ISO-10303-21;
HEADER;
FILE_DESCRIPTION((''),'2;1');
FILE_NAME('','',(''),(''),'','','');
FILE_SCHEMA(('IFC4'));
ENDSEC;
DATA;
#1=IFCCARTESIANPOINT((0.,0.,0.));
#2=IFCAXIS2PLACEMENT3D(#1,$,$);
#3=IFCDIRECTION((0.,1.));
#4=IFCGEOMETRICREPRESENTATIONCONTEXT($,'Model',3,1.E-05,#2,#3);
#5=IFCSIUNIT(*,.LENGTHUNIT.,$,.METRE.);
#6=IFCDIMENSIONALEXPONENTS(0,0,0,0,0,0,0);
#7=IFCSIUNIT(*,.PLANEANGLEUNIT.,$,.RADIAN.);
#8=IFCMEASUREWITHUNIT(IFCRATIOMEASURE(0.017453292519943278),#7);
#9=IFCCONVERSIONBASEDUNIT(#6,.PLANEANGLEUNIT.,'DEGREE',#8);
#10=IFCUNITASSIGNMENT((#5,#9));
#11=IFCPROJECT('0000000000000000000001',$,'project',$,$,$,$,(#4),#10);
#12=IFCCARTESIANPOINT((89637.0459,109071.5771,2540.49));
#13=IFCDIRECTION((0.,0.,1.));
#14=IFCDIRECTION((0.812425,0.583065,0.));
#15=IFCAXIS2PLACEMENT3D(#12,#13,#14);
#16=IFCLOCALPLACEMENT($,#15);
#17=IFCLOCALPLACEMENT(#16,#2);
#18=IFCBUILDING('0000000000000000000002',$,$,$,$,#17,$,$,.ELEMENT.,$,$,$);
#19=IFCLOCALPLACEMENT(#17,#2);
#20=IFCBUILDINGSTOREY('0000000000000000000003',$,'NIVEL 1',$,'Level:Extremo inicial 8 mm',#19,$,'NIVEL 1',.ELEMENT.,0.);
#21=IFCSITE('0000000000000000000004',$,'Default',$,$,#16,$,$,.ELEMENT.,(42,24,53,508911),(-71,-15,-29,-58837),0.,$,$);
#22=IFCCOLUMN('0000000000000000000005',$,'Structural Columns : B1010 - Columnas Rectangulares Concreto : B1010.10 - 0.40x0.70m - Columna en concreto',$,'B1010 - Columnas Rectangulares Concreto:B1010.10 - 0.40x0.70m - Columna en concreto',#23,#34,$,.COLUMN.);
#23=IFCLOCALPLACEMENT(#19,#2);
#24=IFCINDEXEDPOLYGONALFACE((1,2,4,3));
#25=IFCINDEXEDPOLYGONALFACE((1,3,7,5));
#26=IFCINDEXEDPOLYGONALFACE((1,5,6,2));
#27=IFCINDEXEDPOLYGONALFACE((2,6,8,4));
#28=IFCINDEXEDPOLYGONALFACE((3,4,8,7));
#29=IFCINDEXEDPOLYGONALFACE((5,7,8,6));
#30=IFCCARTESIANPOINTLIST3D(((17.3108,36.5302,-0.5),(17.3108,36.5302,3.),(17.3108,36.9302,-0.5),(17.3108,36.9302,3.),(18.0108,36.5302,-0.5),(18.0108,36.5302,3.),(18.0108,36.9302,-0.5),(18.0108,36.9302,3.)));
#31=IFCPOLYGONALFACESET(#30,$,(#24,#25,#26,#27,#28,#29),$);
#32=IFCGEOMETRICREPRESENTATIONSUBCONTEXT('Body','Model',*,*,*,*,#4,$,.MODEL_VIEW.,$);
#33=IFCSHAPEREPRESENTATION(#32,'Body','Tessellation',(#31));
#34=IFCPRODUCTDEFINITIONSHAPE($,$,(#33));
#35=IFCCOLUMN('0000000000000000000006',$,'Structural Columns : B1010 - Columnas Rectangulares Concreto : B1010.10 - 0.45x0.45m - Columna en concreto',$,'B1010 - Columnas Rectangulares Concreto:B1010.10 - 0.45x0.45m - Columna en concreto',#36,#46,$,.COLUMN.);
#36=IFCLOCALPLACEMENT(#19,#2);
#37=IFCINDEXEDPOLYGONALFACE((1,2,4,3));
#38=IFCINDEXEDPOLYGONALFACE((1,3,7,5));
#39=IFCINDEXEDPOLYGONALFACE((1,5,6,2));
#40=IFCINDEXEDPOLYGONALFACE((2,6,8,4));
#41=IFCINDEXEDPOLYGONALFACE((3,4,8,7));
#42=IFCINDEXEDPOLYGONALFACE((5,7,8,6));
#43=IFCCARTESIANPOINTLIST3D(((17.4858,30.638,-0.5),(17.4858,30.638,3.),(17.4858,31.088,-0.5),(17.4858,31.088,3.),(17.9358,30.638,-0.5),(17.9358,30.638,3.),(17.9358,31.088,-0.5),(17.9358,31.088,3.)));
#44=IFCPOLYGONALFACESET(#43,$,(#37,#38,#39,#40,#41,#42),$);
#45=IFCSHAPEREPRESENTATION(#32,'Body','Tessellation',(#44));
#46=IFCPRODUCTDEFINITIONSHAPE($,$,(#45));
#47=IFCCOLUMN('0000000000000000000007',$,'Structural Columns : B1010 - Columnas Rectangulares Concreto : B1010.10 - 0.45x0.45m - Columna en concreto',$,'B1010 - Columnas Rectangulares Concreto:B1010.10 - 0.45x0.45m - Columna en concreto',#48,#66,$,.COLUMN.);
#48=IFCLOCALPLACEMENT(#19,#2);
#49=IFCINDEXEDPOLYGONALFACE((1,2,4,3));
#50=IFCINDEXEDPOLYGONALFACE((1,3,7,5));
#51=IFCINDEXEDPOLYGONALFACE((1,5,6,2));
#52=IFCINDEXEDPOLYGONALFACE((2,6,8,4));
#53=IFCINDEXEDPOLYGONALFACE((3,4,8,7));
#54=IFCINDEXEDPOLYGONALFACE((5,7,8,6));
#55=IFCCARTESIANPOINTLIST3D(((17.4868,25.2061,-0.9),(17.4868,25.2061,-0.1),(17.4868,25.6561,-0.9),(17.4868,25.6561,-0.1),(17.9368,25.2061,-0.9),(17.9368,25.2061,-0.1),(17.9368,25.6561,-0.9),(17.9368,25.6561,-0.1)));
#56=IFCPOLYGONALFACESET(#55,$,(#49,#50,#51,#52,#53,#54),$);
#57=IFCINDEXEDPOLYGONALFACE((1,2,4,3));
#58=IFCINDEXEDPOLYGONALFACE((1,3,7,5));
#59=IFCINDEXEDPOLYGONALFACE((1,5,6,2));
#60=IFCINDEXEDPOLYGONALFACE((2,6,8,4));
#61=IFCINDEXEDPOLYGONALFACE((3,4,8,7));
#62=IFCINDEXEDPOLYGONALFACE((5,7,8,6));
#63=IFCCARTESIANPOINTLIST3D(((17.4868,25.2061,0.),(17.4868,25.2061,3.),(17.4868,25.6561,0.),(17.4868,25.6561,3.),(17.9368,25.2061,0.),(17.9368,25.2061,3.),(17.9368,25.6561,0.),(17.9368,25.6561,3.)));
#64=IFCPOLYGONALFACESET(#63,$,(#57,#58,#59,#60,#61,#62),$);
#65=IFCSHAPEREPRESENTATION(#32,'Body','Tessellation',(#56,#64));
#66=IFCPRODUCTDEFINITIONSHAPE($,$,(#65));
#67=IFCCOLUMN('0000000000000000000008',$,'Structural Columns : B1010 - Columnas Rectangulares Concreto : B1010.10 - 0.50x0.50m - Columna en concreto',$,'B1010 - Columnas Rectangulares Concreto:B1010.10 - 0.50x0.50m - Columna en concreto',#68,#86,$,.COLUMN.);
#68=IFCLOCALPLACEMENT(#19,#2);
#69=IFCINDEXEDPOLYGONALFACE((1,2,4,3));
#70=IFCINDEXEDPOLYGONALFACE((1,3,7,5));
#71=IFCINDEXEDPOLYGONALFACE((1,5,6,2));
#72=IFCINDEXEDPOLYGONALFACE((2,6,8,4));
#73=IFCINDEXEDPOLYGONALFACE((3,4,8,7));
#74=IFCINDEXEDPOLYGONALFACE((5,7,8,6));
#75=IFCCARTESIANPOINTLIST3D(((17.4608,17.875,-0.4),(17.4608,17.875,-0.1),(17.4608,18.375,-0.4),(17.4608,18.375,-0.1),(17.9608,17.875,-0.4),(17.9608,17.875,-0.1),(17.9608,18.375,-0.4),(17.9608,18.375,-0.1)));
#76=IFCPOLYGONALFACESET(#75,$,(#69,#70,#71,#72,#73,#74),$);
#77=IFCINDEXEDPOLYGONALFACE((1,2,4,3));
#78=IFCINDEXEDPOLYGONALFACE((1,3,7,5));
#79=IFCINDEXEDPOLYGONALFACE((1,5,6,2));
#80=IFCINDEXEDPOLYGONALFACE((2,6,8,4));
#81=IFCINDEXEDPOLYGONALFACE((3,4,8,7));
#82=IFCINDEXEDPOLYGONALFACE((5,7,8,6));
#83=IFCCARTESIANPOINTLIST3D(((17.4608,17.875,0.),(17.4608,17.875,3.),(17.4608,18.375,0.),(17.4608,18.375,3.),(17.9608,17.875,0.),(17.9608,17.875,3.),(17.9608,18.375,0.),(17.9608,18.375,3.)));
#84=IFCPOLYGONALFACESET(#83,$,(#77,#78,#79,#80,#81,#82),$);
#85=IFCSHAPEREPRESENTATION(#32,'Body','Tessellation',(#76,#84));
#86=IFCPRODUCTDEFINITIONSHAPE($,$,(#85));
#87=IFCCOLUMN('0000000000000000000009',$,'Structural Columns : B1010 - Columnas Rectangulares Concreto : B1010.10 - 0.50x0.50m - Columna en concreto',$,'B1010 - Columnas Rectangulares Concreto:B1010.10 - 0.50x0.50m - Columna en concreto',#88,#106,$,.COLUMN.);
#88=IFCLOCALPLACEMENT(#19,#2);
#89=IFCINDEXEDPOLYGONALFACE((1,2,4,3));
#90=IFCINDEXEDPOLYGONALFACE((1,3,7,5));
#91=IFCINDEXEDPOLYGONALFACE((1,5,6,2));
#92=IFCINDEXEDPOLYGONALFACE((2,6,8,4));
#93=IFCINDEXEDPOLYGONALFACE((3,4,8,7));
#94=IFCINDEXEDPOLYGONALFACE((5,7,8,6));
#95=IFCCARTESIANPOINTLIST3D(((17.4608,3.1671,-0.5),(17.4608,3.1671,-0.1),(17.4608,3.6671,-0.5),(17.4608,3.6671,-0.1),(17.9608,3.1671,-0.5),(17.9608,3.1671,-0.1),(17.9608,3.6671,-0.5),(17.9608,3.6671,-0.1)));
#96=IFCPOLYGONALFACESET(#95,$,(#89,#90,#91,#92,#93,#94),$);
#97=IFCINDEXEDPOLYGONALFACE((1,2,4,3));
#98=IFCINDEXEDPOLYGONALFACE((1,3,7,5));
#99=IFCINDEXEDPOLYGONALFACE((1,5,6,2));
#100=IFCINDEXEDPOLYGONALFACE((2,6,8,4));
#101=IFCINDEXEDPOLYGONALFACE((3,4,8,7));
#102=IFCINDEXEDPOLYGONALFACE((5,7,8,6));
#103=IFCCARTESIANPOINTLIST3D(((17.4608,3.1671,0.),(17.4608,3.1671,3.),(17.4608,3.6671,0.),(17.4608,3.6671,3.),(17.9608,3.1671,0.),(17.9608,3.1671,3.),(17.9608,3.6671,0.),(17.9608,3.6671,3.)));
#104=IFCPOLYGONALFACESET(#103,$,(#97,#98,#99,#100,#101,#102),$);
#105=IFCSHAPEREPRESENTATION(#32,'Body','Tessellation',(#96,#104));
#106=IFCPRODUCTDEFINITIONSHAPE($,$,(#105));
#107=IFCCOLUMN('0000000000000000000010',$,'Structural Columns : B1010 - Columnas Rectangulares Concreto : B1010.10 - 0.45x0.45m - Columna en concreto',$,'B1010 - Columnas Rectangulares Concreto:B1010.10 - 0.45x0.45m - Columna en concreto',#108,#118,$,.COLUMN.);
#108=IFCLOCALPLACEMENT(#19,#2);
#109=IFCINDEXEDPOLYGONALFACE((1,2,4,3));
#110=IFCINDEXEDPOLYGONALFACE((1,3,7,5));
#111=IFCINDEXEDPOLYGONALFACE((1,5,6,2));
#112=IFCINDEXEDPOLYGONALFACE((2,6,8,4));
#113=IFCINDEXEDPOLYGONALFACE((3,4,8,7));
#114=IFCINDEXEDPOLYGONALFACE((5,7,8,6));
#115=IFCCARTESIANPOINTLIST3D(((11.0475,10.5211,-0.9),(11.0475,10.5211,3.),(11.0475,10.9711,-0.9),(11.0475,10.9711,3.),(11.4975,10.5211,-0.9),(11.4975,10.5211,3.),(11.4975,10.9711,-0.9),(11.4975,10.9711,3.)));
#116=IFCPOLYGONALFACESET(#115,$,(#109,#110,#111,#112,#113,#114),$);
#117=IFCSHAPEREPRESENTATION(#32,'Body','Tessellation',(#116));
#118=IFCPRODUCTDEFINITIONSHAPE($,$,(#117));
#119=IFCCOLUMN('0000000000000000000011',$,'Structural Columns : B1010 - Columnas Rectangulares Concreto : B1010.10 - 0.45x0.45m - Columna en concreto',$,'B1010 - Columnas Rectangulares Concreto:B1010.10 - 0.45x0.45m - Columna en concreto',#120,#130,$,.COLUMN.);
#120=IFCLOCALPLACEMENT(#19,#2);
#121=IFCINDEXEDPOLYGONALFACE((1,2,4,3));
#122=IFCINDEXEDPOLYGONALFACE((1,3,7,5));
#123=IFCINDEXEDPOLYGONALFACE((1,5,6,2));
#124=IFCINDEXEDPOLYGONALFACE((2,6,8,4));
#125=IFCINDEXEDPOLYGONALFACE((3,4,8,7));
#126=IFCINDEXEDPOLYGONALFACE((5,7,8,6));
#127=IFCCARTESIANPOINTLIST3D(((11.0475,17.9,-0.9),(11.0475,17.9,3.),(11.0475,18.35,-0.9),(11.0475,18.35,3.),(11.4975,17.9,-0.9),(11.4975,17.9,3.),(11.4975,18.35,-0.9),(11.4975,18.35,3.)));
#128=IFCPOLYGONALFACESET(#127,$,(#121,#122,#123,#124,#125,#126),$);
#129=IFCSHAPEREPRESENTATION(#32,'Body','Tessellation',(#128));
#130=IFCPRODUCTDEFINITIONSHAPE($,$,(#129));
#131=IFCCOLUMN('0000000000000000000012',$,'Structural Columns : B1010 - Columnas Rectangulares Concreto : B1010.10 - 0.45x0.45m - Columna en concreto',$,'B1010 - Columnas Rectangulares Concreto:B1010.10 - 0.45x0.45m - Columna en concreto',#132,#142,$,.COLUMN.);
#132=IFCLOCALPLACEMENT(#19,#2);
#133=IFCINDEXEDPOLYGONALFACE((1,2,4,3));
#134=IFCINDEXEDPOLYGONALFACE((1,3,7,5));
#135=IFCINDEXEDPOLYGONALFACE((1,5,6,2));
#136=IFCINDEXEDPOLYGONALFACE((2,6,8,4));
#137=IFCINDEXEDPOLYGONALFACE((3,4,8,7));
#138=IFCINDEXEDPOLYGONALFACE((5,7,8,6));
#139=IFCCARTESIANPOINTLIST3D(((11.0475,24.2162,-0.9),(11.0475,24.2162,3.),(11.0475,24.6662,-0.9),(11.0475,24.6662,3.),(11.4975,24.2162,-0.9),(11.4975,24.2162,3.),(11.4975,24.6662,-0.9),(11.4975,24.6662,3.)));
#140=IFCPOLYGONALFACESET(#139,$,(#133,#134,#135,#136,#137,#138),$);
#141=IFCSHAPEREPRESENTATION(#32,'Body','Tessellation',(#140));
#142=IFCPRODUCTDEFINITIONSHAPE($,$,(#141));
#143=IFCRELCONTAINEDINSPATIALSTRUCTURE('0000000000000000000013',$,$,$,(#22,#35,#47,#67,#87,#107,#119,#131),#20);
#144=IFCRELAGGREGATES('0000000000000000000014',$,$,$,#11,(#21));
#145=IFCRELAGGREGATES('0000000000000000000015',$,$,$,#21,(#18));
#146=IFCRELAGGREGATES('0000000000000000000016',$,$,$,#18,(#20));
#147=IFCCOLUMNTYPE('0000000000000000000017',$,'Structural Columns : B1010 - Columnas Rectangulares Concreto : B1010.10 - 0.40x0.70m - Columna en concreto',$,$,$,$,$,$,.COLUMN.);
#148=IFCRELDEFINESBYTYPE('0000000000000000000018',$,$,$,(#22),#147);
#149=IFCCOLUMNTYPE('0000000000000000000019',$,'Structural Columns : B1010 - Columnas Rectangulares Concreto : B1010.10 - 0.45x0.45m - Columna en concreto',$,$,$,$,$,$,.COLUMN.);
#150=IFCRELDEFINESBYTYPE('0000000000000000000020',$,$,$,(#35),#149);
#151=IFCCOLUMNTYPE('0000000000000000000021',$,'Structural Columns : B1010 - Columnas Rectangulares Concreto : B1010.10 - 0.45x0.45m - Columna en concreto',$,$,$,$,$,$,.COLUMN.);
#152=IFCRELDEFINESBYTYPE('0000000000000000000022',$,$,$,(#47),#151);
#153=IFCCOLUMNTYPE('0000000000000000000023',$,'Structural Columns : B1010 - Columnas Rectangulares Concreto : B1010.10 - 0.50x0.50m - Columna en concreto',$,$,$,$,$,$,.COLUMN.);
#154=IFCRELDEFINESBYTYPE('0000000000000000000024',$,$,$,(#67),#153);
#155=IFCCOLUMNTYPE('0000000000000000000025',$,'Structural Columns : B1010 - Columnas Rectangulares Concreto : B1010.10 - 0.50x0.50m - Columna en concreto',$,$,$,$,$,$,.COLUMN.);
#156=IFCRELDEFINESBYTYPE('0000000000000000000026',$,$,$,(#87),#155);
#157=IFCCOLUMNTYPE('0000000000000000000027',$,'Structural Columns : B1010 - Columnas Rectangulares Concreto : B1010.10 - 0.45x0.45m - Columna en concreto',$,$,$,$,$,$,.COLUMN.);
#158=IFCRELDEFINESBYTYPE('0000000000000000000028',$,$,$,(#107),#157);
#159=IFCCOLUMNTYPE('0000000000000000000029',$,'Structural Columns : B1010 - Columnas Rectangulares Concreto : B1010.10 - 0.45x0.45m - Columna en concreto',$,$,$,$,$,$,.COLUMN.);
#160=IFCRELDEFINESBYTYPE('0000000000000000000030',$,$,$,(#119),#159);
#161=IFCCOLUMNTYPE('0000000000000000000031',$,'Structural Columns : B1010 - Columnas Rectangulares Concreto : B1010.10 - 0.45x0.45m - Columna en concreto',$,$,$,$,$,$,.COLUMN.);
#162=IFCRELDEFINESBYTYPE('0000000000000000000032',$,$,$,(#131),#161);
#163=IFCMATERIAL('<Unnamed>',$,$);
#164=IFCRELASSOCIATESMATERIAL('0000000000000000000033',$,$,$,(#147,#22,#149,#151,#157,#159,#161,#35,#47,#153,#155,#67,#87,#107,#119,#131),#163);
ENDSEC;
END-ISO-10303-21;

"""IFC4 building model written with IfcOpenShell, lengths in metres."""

from ifc_helpers import new_model, entity, si_unit, converted_unit, direction, frame, origin, origin_2d_with_axis, place, context, subcontext, project, spatial, polyline, segment, composite_curve, rectangle, outline, extrude, source, transform, mapped, material, material_profile, profile_set, profile_usage, type_object, type_shapes, element, save


model = new_model("IFC4")

# Units and contexts
model_context = context("Model", 3, precision=1e-05, world=origin(), true_north=direction((0.0, 1.0)))
body_context = subcontext(model_context, "Body", "Model", "MODEL_VIEW")
ifc_project = project(units=[si_unit("LENGTHUNIT", "METRE"), converted_unit("PLANEANGLEUNIT", "DEGREE", entity("IfcRatioMeasure", 0.017453292519943278), si_unit("PLANEANGLEUNIT", "RADIAN"), dimensions=[0, 0, 0, 0, 0, 0, 0])], contexts=[model_context])

# Site, building, storey
site_placement = place(None, frame((89637.0459, 109071.5771, 2540.49), z_axis=(0.0, 0.0, 1.0), x_axis=(0.812425, 0.583065, 0.0)))
site = spatial("IfcSite", under=ifc_project, at=site_placement, Name="Default", CompositionType="ELEMENT", RefLatitude=(42, 24, 53, 508911), RefLongitude=(-71, -15, -29, -58837), RefElevation=0.0)
building_placement = place(site_placement, origin())
building = spatial("IfcBuilding", under=site, at=building_placement, CompositionType="ELEMENT")
storey_placement = place(building_placement, origin())
storey = spatial("IfcBuildingStorey", under=building, at=storey_placement, Name="NIVEL 1", ObjectType="Level:Extremo inicial 8 mm", LongName="NIVEL 1", CompositionType="ELEMENT", Elevation=0.0)

# Columns
ifc_material = material(Name="<Unnamed>")
ifc_material_profile_1 = material_profile(ifc_material, outline(composite_curve([segment(polyline([(0.35, 0.2, 0.0), (0.35, -0.2, 0.0)]), True, "CONTINUOUS"), segment(polyline([(0.35, -0.2, 0.0), (-0.35, -0.2, 0.0)]), True, "CONTINUOUS"), segment(polyline([(-0.35, -0.2, 0.0), (-0.35, 0.2, 0.0)]), True, "CONTINUOUS"), segment(polyline([(-0.35, 0.2, 0.0), (0.35, 0.2, 0.0)]), True, "CONTINUOUS")], self_intersect=False), kind="CURVE"), Name="B1010.10 - 0.40x0.70m - Columna en concreto")
ifc_material_profile_2 = material_profile(ifc_material, outline(composite_curve([segment(polyline([(0.35, 0.2, 3.0), (-0.35, 0.2, 3.0)]), True, "CONTINUOUS"), segment(polyline([(-0.35, 0.2, 3.0), (-0.35, -0.2, 3.0)]), True, "CONTINUOUS"), segment(polyline([(-0.35, -0.2, 3.0), (0.35, -0.2, 3.0)]), True, "CONTINUOUS"), segment(polyline([(0.35, -0.2, 3.0), (0.35, 0.2, 3.0)]), True, "CONTINUOUS")], self_intersect=False), kind="CURVE"), Name="B1010.10 - 0.40x0.70m - Columna en concreto")
ifc_profile_set_1 = profile_set([ifc_material_profile_1, ifc_material_profile_2], Name="B1010.10 - 0.40x0.70m - Columna en concreto")
ifc_profile_usage_1 = profile_usage(ifc_profile_set_1)
column_type_1 = type_object("IfcColumnType", Name="Structural Columns : B1010 - Columnas Rectangulares Concreto : B1010.10 - 0.40x0.70m - Columna en concreto", PredefinedType="COLUMN", material=ifc_profile_set_1)
shared_shape_1 = source(origin(), body_context, "Body", "SweptSolid", [
    extrude(rectangle(XDim=0.4, YDim=0.7, at=origin_2d_with_axis()), frame((17.6608, 36.7302, -0.5), z_axis=(0.0, 0.0, 1.0), x_axis=(0.0, -1.0, 0.0)), (0.0, 0.0, 1.0), 3.5),
])
type_shapes(column_type_1, [shared_shape_1])
column_1_placement = place(storey_placement, origin())
element("IfcColumn", 1, at=column_1_placement, inside=storey, type_object=column_type_1, material=ifc_profile_usage_1, Name="Structural Columns : B1010 - Columnas Rectangulares Concreto : B1010.10 - 0.40x0.70m - Columna en concreto", ObjectType="B1010 - Columnas Rectangulares Concreto:B1010.10 - 0.40x0.70m - Columna en concreto", PredefinedType="COLUMN", context=body_context, shape_type="MappedRepresentation", body=[
    mapped(shared_shape_1, transform((0.0, 0.0, 0.0), scale=1.0)),
])
ifc_material_profile_3 = material_profile(ifc_material, outline(composite_curve([segment(polyline([(0.225, 0.225, 0.0), (0.225, -0.225, 0.0)]), True, "CONTINUOUS"), segment(polyline([(0.225, -0.225, 0.0), (-0.225, -0.225, 0.0)]), True, "CONTINUOUS"), segment(polyline([(-0.225, -0.225, 0.0), (-0.225, 0.225, 0.0)]), True, "CONTINUOUS"), segment(polyline([(-0.225, 0.225, 0.0), (0.225, 0.225, 0.0)]), True, "CONTINUOUS")], self_intersect=False), kind="CURVE"), Name="B1010.10 - 0.45x0.45m - Columna en concreto")
ifc_material_profile_4 = material_profile(ifc_material, outline(composite_curve([segment(polyline([(0.225, 0.225, 3.0), (-0.225, 0.225, 3.0)]), True, "CONTINUOUS"), segment(polyline([(-0.225, 0.225, 3.0), (-0.225, -0.225, 3.0)]), True, "CONTINUOUS"), segment(polyline([(-0.225, -0.225, 3.0), (0.225, -0.225, 3.0)]), True, "CONTINUOUS"), segment(polyline([(0.225, -0.225, 3.0), (0.225, 0.225, 3.0)]), True, "CONTINUOUS")], self_intersect=False), kind="CURVE"), Name="B1010.10 - 0.45x0.45m - Columna en concreto")
ifc_profile_set_2 = profile_set([ifc_material_profile_3, ifc_material_profile_4], Name="B1010.10 - 0.45x0.45m - Columna en concreto")
ifc_profile_usage_2 = profile_usage(ifc_profile_set_2)
column_type_2 = type_object("IfcColumnType", Name="Structural Columns : B1010 - Columnas Rectangulares Concreto : B1010.10 - 0.45x0.45m - Columna en concreto", PredefinedType="COLUMN", material=ifc_profile_set_2)
shared_shape_2 = source(origin(), body_context, "Body", "SweptSolid", [
    extrude(rectangle(XDim=0.45, YDim=0.45, at=origin_2d_with_axis()), frame((17.7108, 30.863, -0.5), z_axis=(0.0, 0.0, 1.0), x_axis=(0.0, -1.0, 0.0)), (0.0, 0.0, 1.0), 3.5),
])
type_shapes(column_type_2, [shared_shape_2])
column_2_placement = place(storey_placement, origin())
element("IfcColumn", 2, at=column_2_placement, inside=storey, type_object=column_type_2, material=ifc_profile_usage_2, Name="Structural Columns : B1010 - Columnas Rectangulares Concreto : B1010.10 - 0.45x0.45m - Columna en concreto", ObjectType="B1010 - Columnas Rectangulares Concreto:B1010.10 - 0.45x0.45m - Columna en concreto", PredefinedType="COLUMN", context=body_context, shape_type="MappedRepresentation", body=[
    mapped(shared_shape_2, transform((0.0, 0.0, 0.0), scale=1.0)),
])
ifc_profile_usage_3 = profile_usage(ifc_profile_set_2)
column_type_3 = type_object("IfcColumnType", Name="Structural Columns : B1010 - Columnas Rectangulares Concreto : B1010.10 - 0.45x0.45m - Columna en concreto", PredefinedType="COLUMN", material=ifc_profile_set_2)
shared_shape_3 = source(origin(), body_context, "Body", "SweptSolid", [
    extrude(rectangle(XDim=0.45, YDim=0.45, at=origin_2d_with_axis()), frame((17.7118, 25.4311, -0.9), z_axis=(0.0, 0.0, 1.0), x_axis=(0.0, -1.0, 0.0)), (0.0, 0.0, 1.0), 0.8),
    extrude(rectangle(XDim=0.45, YDim=0.45, at=origin_2d_with_axis()), frame((17.7118, 25.4311, 0.0), z_axis=(0.0, 0.0, 1.0), x_axis=(0.0, -1.0, 0.0)), (0.0, 0.0, 1.0), 3.0),
])
type_shapes(column_type_3, [shared_shape_3])
column_3_placement = place(storey_placement, origin())
element("IfcColumn", 3, at=column_3_placement, inside=storey, type_object=column_type_3, material=ifc_profile_usage_3, Name="Structural Columns : B1010 - Columnas Rectangulares Concreto : B1010.10 - 0.45x0.45m - Columna en concreto", ObjectType="B1010 - Columnas Rectangulares Concreto:B1010.10 - 0.45x0.45m - Columna en concreto", PredefinedType="COLUMN", context=body_context, shape_type="MappedRepresentation", body=[
    mapped(shared_shape_3, transform((0.0, 0.0, 0.0), scale=1.0)),
])
ifc_material_profile_5 = material_profile(ifc_material, outline(composite_curve([segment(polyline([(0.25, 0.25, 0.0), (0.25, -0.25, 0.0)]), True, "CONTINUOUS"), segment(polyline([(0.25, -0.25, 0.0), (-0.25, -0.25, 0.0)]), True, "CONTINUOUS"), segment(polyline([(-0.25, -0.25, 0.0), (-0.25, 0.25, 0.0)]), True, "CONTINUOUS"), segment(polyline([(-0.25, 0.25, 0.0), (0.25, 0.25, 0.0)]), True, "CONTINUOUS")], self_intersect=False), kind="CURVE"), Name="B1010.10 - 0.50x0.50m - Columna en concreto")
ifc_material_profile_6 = material_profile(ifc_material, outline(composite_curve([segment(polyline([(0.25, 0.25, 3.0), (-0.25, 0.25, 3.0)]), True, "CONTINUOUS"), segment(polyline([(-0.25, 0.25, 3.0), (-0.25, -0.25, 3.0)]), True, "CONTINUOUS"), segment(polyline([(-0.25, -0.25, 3.0), (0.25, -0.25, 3.0)]), True, "CONTINUOUS"), segment(polyline([(0.25, -0.25, 3.0), (0.25, 0.25, 3.0)]), True, "CONTINUOUS")], self_intersect=False), kind="CURVE"), Name="B1010.10 - 0.50x0.50m - Columna en concreto")
ifc_profile_set_3 = profile_set([ifc_material_profile_5, ifc_material_profile_6], Name="B1010.10 - 0.50x0.50m - Columna en concreto")
ifc_profile_usage_4 = profile_usage(ifc_profile_set_3)
column_type_4 = type_object("IfcColumnType", Name="Structural Columns : B1010 - Columnas Rectangulares Concreto : B1010.10 - 0.50x0.50m - Columna en concreto", PredefinedType="COLUMN", material=ifc_profile_set_3)
shared_shape_4 = source(origin(), body_context, "Body", "SweptSolid", [
    extrude(rectangle(XDim=0.5, YDim=0.5, at=origin_2d_with_axis()), frame((17.7108, 18.125, -0.4), z_axis=(0.0, 0.0, 1.0), x_axis=(0.0, -1.0, 0.0)), (0.0, 0.0, 1.0), 0.3),
    extrude(rectangle(XDim=0.5, YDim=0.5, at=origin_2d_with_axis()), frame((17.7108, 18.125, 0.0), z_axis=(0.0, 0.0, 1.0), x_axis=(0.0, -1.0, 0.0)), (0.0, 0.0, 1.0), 3.0),
])
type_shapes(column_type_4, [shared_shape_4])
column_4_placement = place(storey_placement, origin())
element("IfcColumn", 4, at=column_4_placement, inside=storey, type_object=column_type_4, material=ifc_profile_usage_4, Name="Structural Columns : B1010 - Columnas Rectangulares Concreto : B1010.10 - 0.50x0.50m - Columna en concreto", ObjectType="B1010 - Columnas Rectangulares Concreto:B1010.10 - 0.50x0.50m - Columna en concreto", PredefinedType="COLUMN", context=body_context, shape_type="MappedRepresentation", body=[
    mapped(shared_shape_4, transform((0.0, 0.0, 0.0), scale=1.0)),
])
ifc_profile_usage_5 = profile_usage(ifc_profile_set_3)
column_type_5 = type_object("IfcColumnType", Name="Structural Columns : B1010 - Columnas Rectangulares Concreto : B1010.10 - 0.50x0.50m - Columna en concreto", PredefinedType="COLUMN", material=ifc_profile_set_3)
shared_shape_5 = source(origin(), body_context, "Body", "SweptSolid", [
    extrude(rectangle(XDim=0.5, YDim=0.5, at=origin_2d_with_axis()), frame((17.7108, 3.4171, -0.5), z_axis=(0.0, 0.0, 1.0), x_axis=(0.0, -1.0, 0.0)), (0.0, 0.0, 1.0), 0.4),
    extrude(rectangle(XDim=0.5, YDim=0.5, at=origin_2d_with_axis()), frame((17.7108, 3.4171, 0.0), z_axis=(0.0, 0.0, 1.0), x_axis=(0.0, -1.0, 0.0)), (0.0, 0.0, 1.0), 3.0),
])
type_shapes(column_type_5, [shared_shape_5])
column_5_placement = place(storey_placement, origin())
element("IfcColumn", 5, at=column_5_placement, inside=storey, type_object=column_type_5, material=ifc_profile_usage_5, Name="Structural Columns : B1010 - Columnas Rectangulares Concreto : B1010.10 - 0.50x0.50m - Columna en concreto", ObjectType="B1010 - Columnas Rectangulares Concreto:B1010.10 - 0.50x0.50m - Columna en concreto", PredefinedType="COLUMN", context=body_context, shape_type="MappedRepresentation", body=[
    mapped(shared_shape_5, transform((0.0, 0.0, 0.0), scale=1.0)),
])
ifc_profile_usage_6 = profile_usage(ifc_profile_set_2)
column_type_6 = type_object("IfcColumnType", Name="Structural Columns : B1010 - Columnas Rectangulares Concreto : B1010.10 - 0.45x0.45m - Columna en concreto", PredefinedType="COLUMN", material=ifc_profile_set_2)
shared_shape_6 = source(origin(), body_context, "Body", "SweptSolid", [
    extrude(rectangle(XDim=0.45, YDim=0.45, at=origin_2d_with_axis()), frame((11.2725, 10.7461, -0.9), z_axis=(0.0, 0.0, 1.0), x_axis=(0.0, -1.0, 0.0)), (0.0, 0.0, 1.0), 3.9),
])
type_shapes(column_type_6, [shared_shape_6])
column_6_placement = place(storey_placement, origin())
element("IfcColumn", 6, at=column_6_placement, inside=storey, type_object=column_type_6, material=ifc_profile_usage_6, Name="Structural Columns : B1010 - Columnas Rectangulares Concreto : B1010.10 - 0.45x0.45m - Columna en concreto", ObjectType="B1010 - Columnas Rectangulares Concreto:B1010.10 - 0.45x0.45m - Columna en concreto", PredefinedType="COLUMN", context=body_context, shape_type="MappedRepresentation", body=[
    mapped(shared_shape_6, transform((0.0, 0.0, 0.0), scale=1.0)),
])
ifc_profile_usage_7 = profile_usage(ifc_profile_set_2)
column_type_7 = type_object("IfcColumnType", Name="Structural Columns : B1010 - Columnas Rectangulares Concreto : B1010.10 - 0.45x0.45m - Columna en concreto", PredefinedType="COLUMN", material=ifc_profile_set_2)
shared_shape_7 = source(origin(), body_context, "Body", "SweptSolid", [
    extrude(rectangle(XDim=0.45, YDim=0.45, at=origin_2d_with_axis()), frame((11.2725, 18.125, -0.9), z_axis=(0.0, 0.0, 1.0), x_axis=(0.0, -1.0, 0.0)), (0.0, 0.0, 1.0), 3.9),
])
type_shapes(column_type_7, [shared_shape_7])
column_7_placement = place(storey_placement, origin())
element("IfcColumn", 7, at=column_7_placement, inside=storey, type_object=column_type_7, material=ifc_profile_usage_7, Name="Structural Columns : B1010 - Columnas Rectangulares Concreto : B1010.10 - 0.45x0.45m - Columna en concreto", ObjectType="B1010 - Columnas Rectangulares Concreto:B1010.10 - 0.45x0.45m - Columna en concreto", PredefinedType="COLUMN", context=body_context, shape_type="MappedRepresentation", body=[
    mapped(shared_shape_7, transform((0.0, 0.0, 0.0), scale=1.0)),
])
ifc_profile_usage_8 = profile_usage(ifc_profile_set_2)
column_type_8 = type_object("IfcColumnType", Name="Structural Columns : B1010 - Columnas Rectangulares Concreto : B1010.10 - 0.45x0.45m - Columna en concreto", PredefinedType="COLUMN", material=ifc_profile_set_2)
shared_shape_8 = source(origin(), body_context, "Body", "SweptSolid", [
    extrude(rectangle(XDim=0.45, YDim=0.45, at=origin_2d_with_axis()), frame((11.2725, 24.4412, -0.9), z_axis=(0.0, 0.0, 1.0), x_axis=(0.0, -1.0, 0.0)), (0.0, 0.0, 1.0), 3.9),
])
type_shapes(column_type_8, [shared_shape_8])
column_8_placement = place(storey_placement, origin())
element("IfcColumn", 8, at=column_8_placement, inside=storey, type_object=column_type_8, material=ifc_profile_usage_8, Name="Structural Columns : B1010 - Columnas Rectangulares Concreto : B1010.10 - 0.45x0.45m - Columna en concreto", ObjectType="B1010 - Columnas Rectangulares Concreto:B1010.10 - 0.45x0.45m - Columna en concreto", PredefinedType="COLUMN", context=body_context, shape_type="MappedRepresentation", body=[
    mapped(shared_shape_8, transform((0.0, 0.0, 0.0), scale=1.0)),
])

save(model, "model.ifc")
